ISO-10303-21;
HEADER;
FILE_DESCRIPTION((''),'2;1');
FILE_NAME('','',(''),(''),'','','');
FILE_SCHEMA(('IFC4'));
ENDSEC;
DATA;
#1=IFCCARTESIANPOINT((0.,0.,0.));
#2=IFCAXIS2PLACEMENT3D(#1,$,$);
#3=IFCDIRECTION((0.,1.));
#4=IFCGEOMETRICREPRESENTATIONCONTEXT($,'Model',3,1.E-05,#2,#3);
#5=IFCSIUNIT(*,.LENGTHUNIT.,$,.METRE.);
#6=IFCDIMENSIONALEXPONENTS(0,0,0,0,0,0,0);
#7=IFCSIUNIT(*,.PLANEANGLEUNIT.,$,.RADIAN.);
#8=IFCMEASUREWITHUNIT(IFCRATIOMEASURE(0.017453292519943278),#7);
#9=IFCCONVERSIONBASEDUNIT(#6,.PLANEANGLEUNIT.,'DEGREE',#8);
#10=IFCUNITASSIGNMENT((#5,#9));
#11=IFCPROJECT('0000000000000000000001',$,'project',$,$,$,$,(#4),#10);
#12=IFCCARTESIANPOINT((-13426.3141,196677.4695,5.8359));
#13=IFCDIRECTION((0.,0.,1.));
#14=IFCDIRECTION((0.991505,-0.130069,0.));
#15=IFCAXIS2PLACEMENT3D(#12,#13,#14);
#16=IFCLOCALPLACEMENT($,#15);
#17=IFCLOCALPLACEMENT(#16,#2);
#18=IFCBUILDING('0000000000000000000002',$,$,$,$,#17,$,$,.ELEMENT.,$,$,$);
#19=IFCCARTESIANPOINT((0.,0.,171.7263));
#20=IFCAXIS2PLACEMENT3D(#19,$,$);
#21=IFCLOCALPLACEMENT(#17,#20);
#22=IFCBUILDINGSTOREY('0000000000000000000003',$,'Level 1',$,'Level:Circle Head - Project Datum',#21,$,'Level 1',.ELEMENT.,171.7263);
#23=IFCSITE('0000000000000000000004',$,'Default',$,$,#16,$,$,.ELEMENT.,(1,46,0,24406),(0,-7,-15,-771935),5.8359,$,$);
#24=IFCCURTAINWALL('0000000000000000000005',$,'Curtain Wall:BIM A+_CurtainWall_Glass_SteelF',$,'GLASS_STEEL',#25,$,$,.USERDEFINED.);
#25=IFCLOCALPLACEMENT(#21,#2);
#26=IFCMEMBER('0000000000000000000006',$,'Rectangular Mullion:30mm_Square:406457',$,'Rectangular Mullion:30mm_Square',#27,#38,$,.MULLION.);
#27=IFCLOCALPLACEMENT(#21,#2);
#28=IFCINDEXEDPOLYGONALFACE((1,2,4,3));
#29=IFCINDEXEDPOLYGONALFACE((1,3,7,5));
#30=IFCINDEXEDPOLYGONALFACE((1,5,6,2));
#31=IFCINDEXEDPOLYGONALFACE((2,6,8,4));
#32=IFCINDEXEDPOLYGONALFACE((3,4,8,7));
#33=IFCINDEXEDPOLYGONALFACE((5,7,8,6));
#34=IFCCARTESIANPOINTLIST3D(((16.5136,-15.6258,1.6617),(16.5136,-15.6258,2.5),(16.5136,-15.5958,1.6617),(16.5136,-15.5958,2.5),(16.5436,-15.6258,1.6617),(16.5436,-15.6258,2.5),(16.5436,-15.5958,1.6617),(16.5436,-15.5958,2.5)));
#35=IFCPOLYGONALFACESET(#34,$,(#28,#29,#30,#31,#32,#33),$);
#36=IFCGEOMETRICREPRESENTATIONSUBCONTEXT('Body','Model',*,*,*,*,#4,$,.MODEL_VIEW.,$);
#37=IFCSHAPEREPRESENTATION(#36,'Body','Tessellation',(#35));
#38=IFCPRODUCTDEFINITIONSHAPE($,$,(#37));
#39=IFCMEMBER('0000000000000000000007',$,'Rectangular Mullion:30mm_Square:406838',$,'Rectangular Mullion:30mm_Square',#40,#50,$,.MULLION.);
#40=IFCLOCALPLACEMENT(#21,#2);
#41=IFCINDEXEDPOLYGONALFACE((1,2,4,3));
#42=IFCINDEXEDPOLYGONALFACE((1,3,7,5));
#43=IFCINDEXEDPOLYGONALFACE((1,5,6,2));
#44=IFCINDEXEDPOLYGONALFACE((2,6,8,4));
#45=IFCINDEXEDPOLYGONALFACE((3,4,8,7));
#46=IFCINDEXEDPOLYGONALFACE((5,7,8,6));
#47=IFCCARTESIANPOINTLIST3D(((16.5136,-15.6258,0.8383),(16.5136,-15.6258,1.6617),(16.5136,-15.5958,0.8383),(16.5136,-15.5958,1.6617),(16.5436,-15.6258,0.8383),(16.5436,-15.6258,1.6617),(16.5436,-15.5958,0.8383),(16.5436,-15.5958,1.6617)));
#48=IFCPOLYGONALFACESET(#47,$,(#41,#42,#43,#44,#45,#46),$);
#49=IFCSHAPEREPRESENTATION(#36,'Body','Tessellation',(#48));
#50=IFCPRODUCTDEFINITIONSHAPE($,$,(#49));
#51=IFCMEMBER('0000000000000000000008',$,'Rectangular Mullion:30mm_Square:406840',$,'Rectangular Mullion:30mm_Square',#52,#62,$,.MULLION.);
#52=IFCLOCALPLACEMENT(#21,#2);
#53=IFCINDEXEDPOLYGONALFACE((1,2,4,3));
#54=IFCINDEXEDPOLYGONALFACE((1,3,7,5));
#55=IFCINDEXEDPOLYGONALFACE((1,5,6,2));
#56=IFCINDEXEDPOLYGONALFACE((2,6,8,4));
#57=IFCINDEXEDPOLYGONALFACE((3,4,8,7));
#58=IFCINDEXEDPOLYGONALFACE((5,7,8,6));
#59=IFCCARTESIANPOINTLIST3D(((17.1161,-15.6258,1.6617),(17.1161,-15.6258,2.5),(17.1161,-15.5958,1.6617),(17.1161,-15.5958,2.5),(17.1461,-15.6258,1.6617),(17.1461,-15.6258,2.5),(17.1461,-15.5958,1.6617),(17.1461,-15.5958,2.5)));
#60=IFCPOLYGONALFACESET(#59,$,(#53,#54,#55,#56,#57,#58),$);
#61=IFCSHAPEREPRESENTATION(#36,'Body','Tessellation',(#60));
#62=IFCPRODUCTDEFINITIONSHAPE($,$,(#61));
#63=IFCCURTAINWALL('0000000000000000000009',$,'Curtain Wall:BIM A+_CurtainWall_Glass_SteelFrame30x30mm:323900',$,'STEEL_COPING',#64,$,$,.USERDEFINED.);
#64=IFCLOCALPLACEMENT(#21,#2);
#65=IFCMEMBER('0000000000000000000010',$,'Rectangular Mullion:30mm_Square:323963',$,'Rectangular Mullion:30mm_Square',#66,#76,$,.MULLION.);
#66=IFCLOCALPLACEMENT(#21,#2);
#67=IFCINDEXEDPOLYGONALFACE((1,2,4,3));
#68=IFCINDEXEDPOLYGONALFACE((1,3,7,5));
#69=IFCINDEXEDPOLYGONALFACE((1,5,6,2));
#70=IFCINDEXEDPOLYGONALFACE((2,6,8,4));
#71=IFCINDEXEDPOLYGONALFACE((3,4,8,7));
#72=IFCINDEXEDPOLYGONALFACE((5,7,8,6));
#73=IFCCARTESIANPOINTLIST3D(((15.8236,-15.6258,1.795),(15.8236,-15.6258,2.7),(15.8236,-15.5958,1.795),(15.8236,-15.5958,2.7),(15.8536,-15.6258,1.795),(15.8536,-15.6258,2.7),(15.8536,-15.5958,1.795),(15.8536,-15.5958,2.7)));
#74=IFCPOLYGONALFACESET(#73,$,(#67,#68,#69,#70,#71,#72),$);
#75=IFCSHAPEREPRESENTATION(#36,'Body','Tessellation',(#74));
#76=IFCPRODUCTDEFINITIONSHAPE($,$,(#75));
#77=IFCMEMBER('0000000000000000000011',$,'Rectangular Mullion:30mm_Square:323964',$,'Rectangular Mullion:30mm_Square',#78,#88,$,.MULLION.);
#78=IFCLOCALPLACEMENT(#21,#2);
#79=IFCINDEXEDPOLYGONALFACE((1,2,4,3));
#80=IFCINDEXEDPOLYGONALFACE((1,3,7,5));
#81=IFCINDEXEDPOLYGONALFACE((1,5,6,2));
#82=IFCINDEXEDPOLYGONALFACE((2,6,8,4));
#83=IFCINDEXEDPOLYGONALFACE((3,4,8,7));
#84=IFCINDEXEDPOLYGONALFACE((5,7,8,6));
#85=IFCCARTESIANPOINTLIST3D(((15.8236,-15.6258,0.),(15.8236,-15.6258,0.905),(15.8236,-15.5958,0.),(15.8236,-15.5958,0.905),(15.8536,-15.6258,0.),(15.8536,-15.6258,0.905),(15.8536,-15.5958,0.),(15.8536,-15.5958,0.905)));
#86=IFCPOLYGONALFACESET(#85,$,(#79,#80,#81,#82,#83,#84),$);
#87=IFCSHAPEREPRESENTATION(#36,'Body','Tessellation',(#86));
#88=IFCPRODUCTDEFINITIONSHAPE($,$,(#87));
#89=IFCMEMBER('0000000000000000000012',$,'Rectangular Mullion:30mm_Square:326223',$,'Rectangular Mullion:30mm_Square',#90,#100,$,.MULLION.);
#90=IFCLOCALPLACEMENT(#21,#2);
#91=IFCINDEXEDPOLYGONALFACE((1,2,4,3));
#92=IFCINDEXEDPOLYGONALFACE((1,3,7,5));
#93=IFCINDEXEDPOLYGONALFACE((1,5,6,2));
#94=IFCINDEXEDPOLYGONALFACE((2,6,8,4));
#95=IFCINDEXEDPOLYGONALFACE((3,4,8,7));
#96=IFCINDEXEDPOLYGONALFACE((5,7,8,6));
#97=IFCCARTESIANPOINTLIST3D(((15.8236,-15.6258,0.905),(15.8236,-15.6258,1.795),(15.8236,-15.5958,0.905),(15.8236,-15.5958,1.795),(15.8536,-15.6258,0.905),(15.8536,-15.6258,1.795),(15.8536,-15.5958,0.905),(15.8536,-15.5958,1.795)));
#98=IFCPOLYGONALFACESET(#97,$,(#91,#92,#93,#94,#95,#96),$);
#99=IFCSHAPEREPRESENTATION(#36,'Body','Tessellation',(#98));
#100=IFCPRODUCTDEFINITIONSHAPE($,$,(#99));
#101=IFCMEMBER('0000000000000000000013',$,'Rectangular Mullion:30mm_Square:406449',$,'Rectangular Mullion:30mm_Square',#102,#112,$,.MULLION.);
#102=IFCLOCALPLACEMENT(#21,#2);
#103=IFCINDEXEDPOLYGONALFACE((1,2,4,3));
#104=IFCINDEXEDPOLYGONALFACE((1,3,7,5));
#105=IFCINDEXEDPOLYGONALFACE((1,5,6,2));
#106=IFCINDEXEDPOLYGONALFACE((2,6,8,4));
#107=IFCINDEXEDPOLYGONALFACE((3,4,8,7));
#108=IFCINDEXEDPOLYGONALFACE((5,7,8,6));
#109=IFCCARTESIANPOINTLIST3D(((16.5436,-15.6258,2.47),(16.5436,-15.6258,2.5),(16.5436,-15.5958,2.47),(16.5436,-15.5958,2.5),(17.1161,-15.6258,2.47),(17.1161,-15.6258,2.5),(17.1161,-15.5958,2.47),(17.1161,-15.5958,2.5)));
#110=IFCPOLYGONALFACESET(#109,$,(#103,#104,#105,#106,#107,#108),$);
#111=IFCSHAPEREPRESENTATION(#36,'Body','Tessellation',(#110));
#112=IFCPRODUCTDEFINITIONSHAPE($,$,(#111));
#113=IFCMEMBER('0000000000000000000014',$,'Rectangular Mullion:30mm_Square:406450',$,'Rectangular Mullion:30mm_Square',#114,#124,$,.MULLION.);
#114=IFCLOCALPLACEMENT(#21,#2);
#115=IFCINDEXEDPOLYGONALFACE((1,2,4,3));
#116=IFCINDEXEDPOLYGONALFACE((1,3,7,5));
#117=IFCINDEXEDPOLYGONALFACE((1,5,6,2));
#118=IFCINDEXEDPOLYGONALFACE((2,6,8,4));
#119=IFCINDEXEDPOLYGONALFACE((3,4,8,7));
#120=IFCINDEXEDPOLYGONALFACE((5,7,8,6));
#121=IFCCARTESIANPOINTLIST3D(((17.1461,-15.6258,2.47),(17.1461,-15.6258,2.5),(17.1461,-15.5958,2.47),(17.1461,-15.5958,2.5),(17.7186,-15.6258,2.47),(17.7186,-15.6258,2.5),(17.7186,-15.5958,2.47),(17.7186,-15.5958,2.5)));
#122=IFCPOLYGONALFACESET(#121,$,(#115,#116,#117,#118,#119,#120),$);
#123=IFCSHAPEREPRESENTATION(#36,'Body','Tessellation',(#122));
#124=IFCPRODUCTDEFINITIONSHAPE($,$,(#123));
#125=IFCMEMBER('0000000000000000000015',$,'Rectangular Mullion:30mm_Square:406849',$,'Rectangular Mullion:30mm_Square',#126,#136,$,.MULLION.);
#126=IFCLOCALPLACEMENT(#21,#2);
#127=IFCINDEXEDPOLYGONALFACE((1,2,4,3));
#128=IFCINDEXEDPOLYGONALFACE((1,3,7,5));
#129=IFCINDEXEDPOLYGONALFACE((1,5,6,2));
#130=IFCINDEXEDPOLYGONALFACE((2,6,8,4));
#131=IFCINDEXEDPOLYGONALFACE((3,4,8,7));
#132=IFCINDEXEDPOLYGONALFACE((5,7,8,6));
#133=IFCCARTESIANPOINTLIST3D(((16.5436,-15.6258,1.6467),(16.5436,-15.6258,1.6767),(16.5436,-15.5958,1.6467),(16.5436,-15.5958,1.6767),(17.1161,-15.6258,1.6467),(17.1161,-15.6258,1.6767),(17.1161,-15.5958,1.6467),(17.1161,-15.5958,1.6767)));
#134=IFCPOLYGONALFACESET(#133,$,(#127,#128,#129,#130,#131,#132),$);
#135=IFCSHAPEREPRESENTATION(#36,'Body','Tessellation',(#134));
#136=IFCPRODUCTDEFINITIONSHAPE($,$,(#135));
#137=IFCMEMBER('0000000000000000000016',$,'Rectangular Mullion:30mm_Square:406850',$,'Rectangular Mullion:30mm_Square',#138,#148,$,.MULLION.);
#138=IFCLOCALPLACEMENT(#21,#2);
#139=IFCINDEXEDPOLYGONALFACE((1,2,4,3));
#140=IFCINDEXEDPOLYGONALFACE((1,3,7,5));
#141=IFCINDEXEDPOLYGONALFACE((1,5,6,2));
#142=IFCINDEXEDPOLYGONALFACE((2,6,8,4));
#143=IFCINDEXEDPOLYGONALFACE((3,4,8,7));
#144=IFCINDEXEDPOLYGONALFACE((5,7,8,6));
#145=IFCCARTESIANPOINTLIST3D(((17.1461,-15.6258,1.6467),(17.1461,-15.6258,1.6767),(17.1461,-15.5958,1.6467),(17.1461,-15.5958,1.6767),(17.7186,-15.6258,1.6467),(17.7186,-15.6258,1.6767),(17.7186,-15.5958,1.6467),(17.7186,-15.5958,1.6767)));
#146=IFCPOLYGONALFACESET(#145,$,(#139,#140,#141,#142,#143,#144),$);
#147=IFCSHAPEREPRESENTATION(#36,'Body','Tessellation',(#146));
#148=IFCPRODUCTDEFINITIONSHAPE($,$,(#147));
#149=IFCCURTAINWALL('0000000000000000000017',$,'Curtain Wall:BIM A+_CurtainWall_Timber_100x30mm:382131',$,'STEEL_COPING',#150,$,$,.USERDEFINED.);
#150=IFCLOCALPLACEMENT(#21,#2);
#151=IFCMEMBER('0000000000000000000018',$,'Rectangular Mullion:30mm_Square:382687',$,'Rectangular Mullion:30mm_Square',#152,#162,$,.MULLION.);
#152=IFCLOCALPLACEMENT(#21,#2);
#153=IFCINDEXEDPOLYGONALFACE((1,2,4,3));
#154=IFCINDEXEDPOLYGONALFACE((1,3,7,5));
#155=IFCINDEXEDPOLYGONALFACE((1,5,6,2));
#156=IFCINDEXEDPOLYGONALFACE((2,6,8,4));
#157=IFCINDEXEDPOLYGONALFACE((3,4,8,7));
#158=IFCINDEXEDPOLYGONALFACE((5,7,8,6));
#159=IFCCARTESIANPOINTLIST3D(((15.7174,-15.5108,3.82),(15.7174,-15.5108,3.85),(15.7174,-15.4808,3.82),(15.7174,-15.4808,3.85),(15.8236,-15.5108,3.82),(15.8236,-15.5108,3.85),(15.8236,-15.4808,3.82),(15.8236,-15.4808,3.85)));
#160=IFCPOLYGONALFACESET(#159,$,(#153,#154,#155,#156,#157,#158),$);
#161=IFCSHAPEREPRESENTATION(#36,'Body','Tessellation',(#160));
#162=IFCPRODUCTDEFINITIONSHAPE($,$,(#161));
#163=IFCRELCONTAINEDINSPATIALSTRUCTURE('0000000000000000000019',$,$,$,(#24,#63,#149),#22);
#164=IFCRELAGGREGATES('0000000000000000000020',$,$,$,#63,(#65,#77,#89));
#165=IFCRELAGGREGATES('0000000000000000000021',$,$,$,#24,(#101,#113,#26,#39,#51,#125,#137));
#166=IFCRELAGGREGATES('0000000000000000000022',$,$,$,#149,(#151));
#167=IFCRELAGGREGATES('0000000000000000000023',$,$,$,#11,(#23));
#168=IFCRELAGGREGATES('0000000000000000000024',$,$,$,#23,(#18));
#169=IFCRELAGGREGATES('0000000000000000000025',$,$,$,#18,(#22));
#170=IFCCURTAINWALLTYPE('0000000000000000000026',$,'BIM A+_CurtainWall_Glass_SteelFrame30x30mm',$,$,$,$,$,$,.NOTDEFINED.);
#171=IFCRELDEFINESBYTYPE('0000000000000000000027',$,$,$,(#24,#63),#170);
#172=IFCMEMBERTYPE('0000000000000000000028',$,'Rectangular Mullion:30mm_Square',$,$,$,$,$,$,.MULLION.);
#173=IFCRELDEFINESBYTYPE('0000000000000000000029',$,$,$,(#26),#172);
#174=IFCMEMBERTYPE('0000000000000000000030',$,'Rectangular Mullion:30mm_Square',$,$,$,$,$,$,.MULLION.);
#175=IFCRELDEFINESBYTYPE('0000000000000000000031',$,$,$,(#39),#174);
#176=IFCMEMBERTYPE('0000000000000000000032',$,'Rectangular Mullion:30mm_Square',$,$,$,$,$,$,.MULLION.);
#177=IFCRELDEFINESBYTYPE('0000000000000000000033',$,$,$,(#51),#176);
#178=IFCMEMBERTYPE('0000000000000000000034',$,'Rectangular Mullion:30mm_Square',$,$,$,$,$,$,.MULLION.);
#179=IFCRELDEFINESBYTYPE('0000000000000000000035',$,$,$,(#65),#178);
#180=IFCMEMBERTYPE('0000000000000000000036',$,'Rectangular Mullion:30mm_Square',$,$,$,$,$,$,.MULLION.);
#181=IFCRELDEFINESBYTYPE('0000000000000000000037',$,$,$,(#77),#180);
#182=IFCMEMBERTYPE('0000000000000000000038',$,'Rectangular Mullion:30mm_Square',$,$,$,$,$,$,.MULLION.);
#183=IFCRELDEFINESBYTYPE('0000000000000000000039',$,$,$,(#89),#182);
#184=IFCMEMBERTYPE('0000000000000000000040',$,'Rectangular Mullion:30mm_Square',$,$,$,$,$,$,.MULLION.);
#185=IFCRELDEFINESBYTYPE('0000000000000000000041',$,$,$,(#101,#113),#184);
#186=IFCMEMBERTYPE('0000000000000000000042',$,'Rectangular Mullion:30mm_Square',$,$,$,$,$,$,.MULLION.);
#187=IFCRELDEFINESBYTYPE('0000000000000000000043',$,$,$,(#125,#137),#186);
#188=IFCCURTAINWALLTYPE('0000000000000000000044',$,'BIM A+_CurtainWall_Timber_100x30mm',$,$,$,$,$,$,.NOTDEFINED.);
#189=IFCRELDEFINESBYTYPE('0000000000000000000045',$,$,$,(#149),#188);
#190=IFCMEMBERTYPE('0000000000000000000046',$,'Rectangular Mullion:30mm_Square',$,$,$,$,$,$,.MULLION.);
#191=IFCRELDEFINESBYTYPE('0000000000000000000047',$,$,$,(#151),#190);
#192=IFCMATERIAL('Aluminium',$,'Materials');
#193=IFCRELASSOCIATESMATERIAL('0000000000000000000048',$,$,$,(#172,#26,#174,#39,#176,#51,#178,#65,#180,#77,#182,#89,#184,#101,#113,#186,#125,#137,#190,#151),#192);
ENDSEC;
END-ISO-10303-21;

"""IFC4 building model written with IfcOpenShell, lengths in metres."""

from ifc_helpers import new_model, entity, si_unit, converted_unit, direction, frame, origin, place, context, subcontext, project, spatial, indexed_curve, outline, extrude, source, transform, mapped, material, type_object, type_shapes, element, aggregate, save


model = new_model("IFC4")

# Units and contexts
model_context = context("Model", 3, precision=1e-05, world=origin(), true_north=direction((0.0, 1.0)))
body_context = subcontext(model_context, "Body", "Model", "MODEL_VIEW")
ifc_project = project(units=[si_unit("LENGTHUNIT", "METRE"), converted_unit("PLANEANGLEUNIT", "DEGREE", entity("IfcRatioMeasure", 0.017453292519943278), si_unit("PLANEANGLEUNIT", "RADIAN"), dimensions=[0, 0, 0, 0, 0, 0, 0])], contexts=[model_context])

# Site, building, storey
site_placement = place(None, frame((-13426.3141, 196677.4695, 5.8359), z_axis=(0.0, 0.0, 1.0), x_axis=(0.991505, -0.130069, 0.0)))
site = spatial("IfcSite", under=ifc_project, at=site_placement, Name="Default", CompositionType="ELEMENT", RefLatitude=(1, 46, 0, 24406), RefLongitude=(0, -7, -15, -771935), RefElevation=5.8359)
building_placement = place(site_placement, origin())
building = spatial("IfcBuilding", under=site, at=building_placement, CompositionType="ELEMENT")
storey_placement = place(building_placement, frame((0.0, 0.0, 171.7263)))
storey = spatial("IfcBuildingStorey", under=building, at=storey_placement, Name="Level 1", ObjectType="Level:Circle Head - Project Datum", LongName="Level 1", CompositionType="ELEMENT", Elevation=171.7263)

# Curtain walls, members
curtain_wall_type_1 = type_object("IfcCurtainWallType", Name="BIM A+_CurtainWall_Glass_SteelFrame30x30mm", PredefinedType="NOTDEFINED")
curtain_wall_1_placement = place(storey_placement, frame((0.0, 0.0, -171.7263)))
curtain_wall_1 = element("IfcCurtainWall", 1, at=curtain_wall_1_placement, inside=storey, type_object=curtain_wall_type_1, Name="Curtain Wall:BIM A+_CurtainWall_Glass_SteelF", ObjectType="GLASS_STEEL", PredefinedType="USERDEFINED")
ifc_material_1 = material(Name="Aluminium", Category="Materials")
member_type_1 = type_object("IfcMemberType", Name="Rectangular Mullion:30mm_Square", PredefinedType="MULLION", material=ifc_material_1)
shared_shape_1 = source(origin(), body_context, "Body", "SweptSolid", [
    extrude(outline(indexed_curve([(-0.015, -0.015), (0.015, -0.015), (0.015, 0.015), (-0.015, 0.015), (-0.015, -0.015)], self_intersect=False)), frame((-0.015, 0.0, -0.8383), z_axis=(0.0, 0.0, 1.0), x_axis=(0.0, -1.0, 0.0)), (0.0, 0.0, 1.0), 0.8383),
])
type_shapes(member_type_1, [shared_shape_1])
member_1_placement = place(curtain_wall_1_placement, frame((16.5136, -15.6108, 174.2263), z_axis=(0.0, 0.0, 1.0), x_axis=(-1.0, 0.0, 0.0)))
member_1 = element("IfcMember", 2, at=member_1_placement, type_object=member_type_1, material=ifc_material_1, Name="Rectangular Mullion:30mm_Square:406457", ObjectType="Rectangular Mullion:30mm_Square", PredefinedType="MULLION", context=body_context, shape_type="MappedRepresentation", body=[
    mapped(shared_shape_1, transform((0.0, 0.0, 0.0), scale=1.0)),
])
member_type_2 = type_object("IfcMemberType", Name="Rectangular Mullion:30mm_Square", PredefinedType="MULLION", material=ifc_material_1)
shared_shape_2 = source(origin(), body_context, "Body", "SweptSolid", [
    extrude(outline(indexed_curve([(-0.015, -0.015), (0.015, -0.015), (0.015, 0.015), (-0.015, 0.015), (-0.015, -0.015)], self_intersect=False)), frame((-0.015, 0.0, -0.8233), z_axis=(0.0, 0.0, 1.0), x_axis=(0.0, -1.0, 0.0)), (0.0, 0.0, 1.0), 0.8233),
])
type_shapes(member_type_2, [shared_shape_2])
member_2_placement = place(curtain_wall_1_placement, frame((16.5136, -15.6108, 173.3879), z_axis=(0.0, 0.0, 1.0), x_axis=(-1.0, 0.0, 0.0)))
member_2 = element("IfcMember", 3, at=member_2_placement, type_object=member_type_2, material=ifc_material_1, Name="Rectangular Mullion:30mm_Square:406838", ObjectType="Rectangular Mullion:30mm_Square", PredefinedType="MULLION", context=body_context, shape_type="MappedRepresentation", body=[
    mapped(shared_shape_2, transform((0.0, 0.0, 0.0), scale=1.0)),
])
member_type_3 = type_object("IfcMemberType", Name="Rectangular Mullion:30mm_Square", PredefinedType="MULLION", material=ifc_material_1)
shared_shape_3 = source(origin(), body_context, "Body", "SweptSolid", [
    extrude(outline(indexed_curve([(-0.015, -0.015), (0.015, -0.015), (0.015, 0.015), (-0.015, 0.015), (-0.015, -0.015)], self_intersect=False)), frame((0.0, 0.0, -0.8383), z_axis=(0.0, 0.0, 1.0), x_axis=(0.0, -1.0, 0.0)), (0.0, 0.0, 1.0), 0.8383),
])
type_shapes(member_type_3, [shared_shape_3])
member_3_placement = place(curtain_wall_1_placement, frame((17.1311, -15.6108, 173.3879), z_axis=(0.0, 0.0, -1.0), x_axis=(1.0, 0.0, 0.0)))
member_3 = element("IfcMember", 4, at=member_3_placement, type_object=member_type_3, material=ifc_material_1, Name="Rectangular Mullion:30mm_Square:406840", ObjectType="Rectangular Mullion:30mm_Square", PredefinedType="MULLION", context=body_context, shape_type="MappedRepresentation", body=[
    mapped(shared_shape_3, transform((0.0, 0.0, 0.0), scale=1.0)),
])
curtain_wall_2_placement = place(storey_placement, frame((0.0, 0.0, -171.7263)))
curtain_wall_2 = element("IfcCurtainWall", 5, at=curtain_wall_2_placement, inside=storey, type_object=curtain_wall_type_1, Name="Curtain Wall:BIM A+_CurtainWall_Glass_SteelFrame30x30mm:323900", ObjectType="STEEL_COPING", PredefinedType="USERDEFINED")
member_type_4 = type_object("IfcMemberType", Name="Rectangular Mullion:30mm_Square", PredefinedType="MULLION", material=ifc_material_1)
shared_shape_4 = source(origin(), body_context, "Body", "SweptSolid", [
    extrude(outline(indexed_curve([(-0.015, -0.015), (0.015, -0.015), (0.015, 0.015), (-0.015, 0.015), (-0.015, -0.015)], self_intersect=False)), frame((-0.015, 0.0, -0.905), z_axis=(0.0, 0.0, 1.0), x_axis=(0.0, -1.0, 0.0)), (0.0, 0.0, 1.0), 0.905),
])
type_shapes(member_type_4, [shared_shape_4])
member_4_placement = place(curtain_wall_2_placement, frame((15.8536, -15.6108, 174.4263)))
member_4 = element("IfcMember", 6, at=member_4_placement, type_object=member_type_4, material=ifc_material_1, Name="Rectangular Mullion:30mm_Square:323963", ObjectType="Rectangular Mullion:30mm_Square", PredefinedType="MULLION", context=body_context, shape_type="MappedRepresentation", body=[
    mapped(shared_shape_4, transform((0.0, 0.0, 0.0), scale=1.0)),
])
member_type_5 = type_object("IfcMemberType", Name="Rectangular Mullion:30mm_Square", PredefinedType="MULLION", material=ifc_material_1)
shared_shape_5 = source(origin(), body_context, "Body", "SweptSolid", [
    extrude(outline(indexed_curve([(-0.015, -0.015), (0.015, -0.015), (0.015, 0.015), (-0.015, 0.015), (-0.015, -0.015)], self_intersect=False)), frame((-0.015, 0.0, -0.905), z_axis=(0.0, 0.0, 1.0), x_axis=(0.0, -1.0, 0.0)), (0.0, 0.0, 1.0), 0.905),
])
type_shapes(member_type_5, [shared_shape_5])
member_5_placement = place(curtain_wall_2_placement, frame((15.8536, -15.6108, 172.6313)))
member_5 = element("IfcMember", 7, at=member_5_placement, type_object=member_type_5, material=ifc_material_1, Name="Rectangular Mullion:30mm_Square:323964", ObjectType="Rectangular Mullion:30mm_Square", PredefinedType="MULLION", context=body_context, shape_type="MappedRepresentation", body=[
    mapped(shared_shape_5, transform((0.0, 0.0, 0.0), scale=1.0)),
])
member_type_6 = type_object("IfcMemberType", Name="Rectangular Mullion:30mm_Square", PredefinedType="MULLION", material=ifc_material_1)
shared_shape_6 = source(origin(), body_context, "Body", "SweptSolid", [
    extrude(outline(indexed_curve([(-0.015, -0.015), (0.015, -0.015), (0.015, 0.015), (-0.015, 0.015), (-0.015, -0.015)], self_intersect=False)), frame((-0.015, 0.0, -0.89), z_axis=(0.0, 0.0, 1.0), x_axis=(0.0, -1.0, 0.0)), (0.0, 0.0, 1.0), 0.89),
])
type_shapes(member_type_6, [shared_shape_6])
member_6_placement = place(curtain_wall_2_placement, frame((15.8536, -15.6108, 173.5213)))
member_6 = element("IfcMember", 8, at=member_6_placement, type_object=member_type_6, material=ifc_material_1, Name="Rectangular Mullion:30mm_Square:326223", ObjectType="Rectangular Mullion:30mm_Square", PredefinedType="MULLION", context=body_context, shape_type="MappedRepresentation", body=[
    mapped(shared_shape_6, transform((0.0, 0.0, 0.0), scale=1.0)),
])

# Members
member_type_7 = type_object("IfcMemberType", Name="Rectangular Mullion:30mm_Square", PredefinedType="MULLION", material=ifc_material_1)
shared_shape_7 = source(origin(), body_context, "Body", "SweptSolid", [
    extrude(outline(indexed_curve([(-0.015, -0.015), (0.015, -0.015), (0.015, 0.015), (-0.015, 0.015), (-0.015, -0.015)], self_intersect=False)), frame((-0.015, 0.0, -0.5725), z_axis=(0.0, 0.0, 1.0), x_axis=(0.0, -1.0, 0.0)), (0.0, 0.0, 1.0), 0.5725),
])
type_shapes(member_type_7, [shared_shape_7])
member_7_placement = place(curtain_wall_1_placement, frame((17.1161, -15.6108, 174.2263), z_axis=(1.0, 0.0, 0.0), x_axis=(0.0, 0.0, 1.0)))
member_7 = element("IfcMember", 9, at=member_7_placement, type_object=member_type_7, material=ifc_material_1, Name="Rectangular Mullion:30mm_Square:406449", ObjectType="Rectangular Mullion:30mm_Square", PredefinedType="MULLION", context=body_context, shape_type="MappedRepresentation", body=[
    mapped(shared_shape_7, transform((0.0, 0.0, 0.0), scale=1.0)),
])
member_8_placement = place(curtain_wall_1_placement, frame((17.7186, -15.6108, 174.2263), z_axis=(1.0, 0.0, 0.0), x_axis=(0.0, 0.0, 1.0)))
member_8 = element("IfcMember", 10, at=member_8_placement, type_object=member_type_7, material=ifc_material_1, Name="Rectangular Mullion:30mm_Square:406450", ObjectType="Rectangular Mullion:30mm_Square", PredefinedType="MULLION", context=body_context, shape_type="MappedRepresentation", body=[
    mapped(shared_shape_7, transform((0.0, 0.0, 0.0), scale=1.0)),
])
member_type_8 = type_object("IfcMemberType", Name="Rectangular Mullion:30mm_Square", PredefinedType="MULLION", material=ifc_material_1)
shared_shape_8 = source(origin(), body_context, "Body", "SweptSolid", [
    extrude(outline(indexed_curve([(-0.015, -0.015), (0.015, -0.015), (0.015, 0.015), (-0.015, 0.015), (-0.015, -0.015)], self_intersect=False)), frame((0.0, 0.0, -0.5725), z_axis=(0.0, 0.0, 1.0), x_axis=(0.0, -1.0, 0.0)), (0.0, 0.0, 1.0), 0.5725),
])
type_shapes(member_type_8, [shared_shape_8])
member_9_placement = place(curtain_wall_1_placement, frame((17.1161, -15.6108, 173.3879), z_axis=(1.0, 0.0, 0.0), x_axis=(0.0, 0.0, 1.0)))
member_9 = element("IfcMember", 11, at=member_9_placement, type_object=member_type_8, material=ifc_material_1, Name="Rectangular Mullion:30mm_Square:406849", ObjectType="Rectangular Mullion:30mm_Square", PredefinedType="MULLION", context=body_context, shape_type="MappedRepresentation", body=[
    mapped(shared_shape_8, transform((0.0, 0.0, 0.0), scale=1.0)),
])
member_10_placement = place(curtain_wall_1_placement, frame((17.7186, -15.6108, 173.3879), z_axis=(1.0, 0.0, 0.0), x_axis=(0.0, 0.0, 1.0)))
member_10 = element("IfcMember", 12, at=member_10_placement, type_object=member_type_8, material=ifc_material_1, Name="Rectangular Mullion:30mm_Square:406850", ObjectType="Rectangular Mullion:30mm_Square", PredefinedType="MULLION", context=body_context, shape_type="MappedRepresentation", body=[
    mapped(shared_shape_8, transform((0.0, 0.0, 0.0), scale=1.0)),
])

# Curtain wall, member
curtain_wall_type_2 = type_object("IfcCurtainWallType", Name="BIM A+_CurtainWall_Timber_100x30mm", PredefinedType="NOTDEFINED")
curtain_wall_3_placement = place(storey_placement, frame((0.0, 0.0, -171.7263)))
curtain_wall_3 = element("IfcCurtainWall", 13, at=curtain_wall_3_placement, inside=storey, type_object=curtain_wall_type_2, Name="Curtain Wall:BIM A+_CurtainWall_Timber_100x30mm:382131", ObjectType="STEEL_COPING", PredefinedType="USERDEFINED")
member_type_9 = type_object("IfcMemberType", Name="Rectangular Mullion:30mm_Square", PredefinedType="MULLION", material=ifc_material_1)
shared_shape_9 = source(origin(), body_context, "Body", "SweptSolid", [
    extrude(outline(indexed_curve([(-0.015, -0.015), (0.015, -0.015), (0.015, 0.015), (-0.015, 0.015), (-0.015, -0.015)], self_intersect=False)), frame((-0.015, 0.0, -0.1062), z_axis=(0.0, 0.0, 1.0), x_axis=(0.0, -1.0, 0.0)), (0.0, 0.0, 1.0), 0.1062),
])
type_shapes(member_type_9, [shared_shape_9])
member_11_placement = place(curtain_wall_3_placement, frame((15.8236, -15.4958, 175.5763), z_axis=(1.0, 0.0, 0.0), x_axis=(0.0, 0.0, 1.0)))
member_11 = element("IfcMember", 14, at=member_11_placement, type_object=member_type_9, material=ifc_material_1, Name="Rectangular Mullion:30mm_Square:382687", ObjectType="Rectangular Mullion:30mm_Square", PredefinedType="MULLION", context=body_context, shape_type="MappedRepresentation", body=[
    mapped(shared_shape_9, transform((0.0, 0.0, 0.0), scale=1.0)),
])

aggregate(curtain_wall_2, [member_4, member_5, member_6])
aggregate(curtain_wall_1, [member_7, member_8, member_1, member_2, member_3, member_9, member_10])
aggregate(curtain_wall_3, [member_11])

save(model, "model.ifc")
